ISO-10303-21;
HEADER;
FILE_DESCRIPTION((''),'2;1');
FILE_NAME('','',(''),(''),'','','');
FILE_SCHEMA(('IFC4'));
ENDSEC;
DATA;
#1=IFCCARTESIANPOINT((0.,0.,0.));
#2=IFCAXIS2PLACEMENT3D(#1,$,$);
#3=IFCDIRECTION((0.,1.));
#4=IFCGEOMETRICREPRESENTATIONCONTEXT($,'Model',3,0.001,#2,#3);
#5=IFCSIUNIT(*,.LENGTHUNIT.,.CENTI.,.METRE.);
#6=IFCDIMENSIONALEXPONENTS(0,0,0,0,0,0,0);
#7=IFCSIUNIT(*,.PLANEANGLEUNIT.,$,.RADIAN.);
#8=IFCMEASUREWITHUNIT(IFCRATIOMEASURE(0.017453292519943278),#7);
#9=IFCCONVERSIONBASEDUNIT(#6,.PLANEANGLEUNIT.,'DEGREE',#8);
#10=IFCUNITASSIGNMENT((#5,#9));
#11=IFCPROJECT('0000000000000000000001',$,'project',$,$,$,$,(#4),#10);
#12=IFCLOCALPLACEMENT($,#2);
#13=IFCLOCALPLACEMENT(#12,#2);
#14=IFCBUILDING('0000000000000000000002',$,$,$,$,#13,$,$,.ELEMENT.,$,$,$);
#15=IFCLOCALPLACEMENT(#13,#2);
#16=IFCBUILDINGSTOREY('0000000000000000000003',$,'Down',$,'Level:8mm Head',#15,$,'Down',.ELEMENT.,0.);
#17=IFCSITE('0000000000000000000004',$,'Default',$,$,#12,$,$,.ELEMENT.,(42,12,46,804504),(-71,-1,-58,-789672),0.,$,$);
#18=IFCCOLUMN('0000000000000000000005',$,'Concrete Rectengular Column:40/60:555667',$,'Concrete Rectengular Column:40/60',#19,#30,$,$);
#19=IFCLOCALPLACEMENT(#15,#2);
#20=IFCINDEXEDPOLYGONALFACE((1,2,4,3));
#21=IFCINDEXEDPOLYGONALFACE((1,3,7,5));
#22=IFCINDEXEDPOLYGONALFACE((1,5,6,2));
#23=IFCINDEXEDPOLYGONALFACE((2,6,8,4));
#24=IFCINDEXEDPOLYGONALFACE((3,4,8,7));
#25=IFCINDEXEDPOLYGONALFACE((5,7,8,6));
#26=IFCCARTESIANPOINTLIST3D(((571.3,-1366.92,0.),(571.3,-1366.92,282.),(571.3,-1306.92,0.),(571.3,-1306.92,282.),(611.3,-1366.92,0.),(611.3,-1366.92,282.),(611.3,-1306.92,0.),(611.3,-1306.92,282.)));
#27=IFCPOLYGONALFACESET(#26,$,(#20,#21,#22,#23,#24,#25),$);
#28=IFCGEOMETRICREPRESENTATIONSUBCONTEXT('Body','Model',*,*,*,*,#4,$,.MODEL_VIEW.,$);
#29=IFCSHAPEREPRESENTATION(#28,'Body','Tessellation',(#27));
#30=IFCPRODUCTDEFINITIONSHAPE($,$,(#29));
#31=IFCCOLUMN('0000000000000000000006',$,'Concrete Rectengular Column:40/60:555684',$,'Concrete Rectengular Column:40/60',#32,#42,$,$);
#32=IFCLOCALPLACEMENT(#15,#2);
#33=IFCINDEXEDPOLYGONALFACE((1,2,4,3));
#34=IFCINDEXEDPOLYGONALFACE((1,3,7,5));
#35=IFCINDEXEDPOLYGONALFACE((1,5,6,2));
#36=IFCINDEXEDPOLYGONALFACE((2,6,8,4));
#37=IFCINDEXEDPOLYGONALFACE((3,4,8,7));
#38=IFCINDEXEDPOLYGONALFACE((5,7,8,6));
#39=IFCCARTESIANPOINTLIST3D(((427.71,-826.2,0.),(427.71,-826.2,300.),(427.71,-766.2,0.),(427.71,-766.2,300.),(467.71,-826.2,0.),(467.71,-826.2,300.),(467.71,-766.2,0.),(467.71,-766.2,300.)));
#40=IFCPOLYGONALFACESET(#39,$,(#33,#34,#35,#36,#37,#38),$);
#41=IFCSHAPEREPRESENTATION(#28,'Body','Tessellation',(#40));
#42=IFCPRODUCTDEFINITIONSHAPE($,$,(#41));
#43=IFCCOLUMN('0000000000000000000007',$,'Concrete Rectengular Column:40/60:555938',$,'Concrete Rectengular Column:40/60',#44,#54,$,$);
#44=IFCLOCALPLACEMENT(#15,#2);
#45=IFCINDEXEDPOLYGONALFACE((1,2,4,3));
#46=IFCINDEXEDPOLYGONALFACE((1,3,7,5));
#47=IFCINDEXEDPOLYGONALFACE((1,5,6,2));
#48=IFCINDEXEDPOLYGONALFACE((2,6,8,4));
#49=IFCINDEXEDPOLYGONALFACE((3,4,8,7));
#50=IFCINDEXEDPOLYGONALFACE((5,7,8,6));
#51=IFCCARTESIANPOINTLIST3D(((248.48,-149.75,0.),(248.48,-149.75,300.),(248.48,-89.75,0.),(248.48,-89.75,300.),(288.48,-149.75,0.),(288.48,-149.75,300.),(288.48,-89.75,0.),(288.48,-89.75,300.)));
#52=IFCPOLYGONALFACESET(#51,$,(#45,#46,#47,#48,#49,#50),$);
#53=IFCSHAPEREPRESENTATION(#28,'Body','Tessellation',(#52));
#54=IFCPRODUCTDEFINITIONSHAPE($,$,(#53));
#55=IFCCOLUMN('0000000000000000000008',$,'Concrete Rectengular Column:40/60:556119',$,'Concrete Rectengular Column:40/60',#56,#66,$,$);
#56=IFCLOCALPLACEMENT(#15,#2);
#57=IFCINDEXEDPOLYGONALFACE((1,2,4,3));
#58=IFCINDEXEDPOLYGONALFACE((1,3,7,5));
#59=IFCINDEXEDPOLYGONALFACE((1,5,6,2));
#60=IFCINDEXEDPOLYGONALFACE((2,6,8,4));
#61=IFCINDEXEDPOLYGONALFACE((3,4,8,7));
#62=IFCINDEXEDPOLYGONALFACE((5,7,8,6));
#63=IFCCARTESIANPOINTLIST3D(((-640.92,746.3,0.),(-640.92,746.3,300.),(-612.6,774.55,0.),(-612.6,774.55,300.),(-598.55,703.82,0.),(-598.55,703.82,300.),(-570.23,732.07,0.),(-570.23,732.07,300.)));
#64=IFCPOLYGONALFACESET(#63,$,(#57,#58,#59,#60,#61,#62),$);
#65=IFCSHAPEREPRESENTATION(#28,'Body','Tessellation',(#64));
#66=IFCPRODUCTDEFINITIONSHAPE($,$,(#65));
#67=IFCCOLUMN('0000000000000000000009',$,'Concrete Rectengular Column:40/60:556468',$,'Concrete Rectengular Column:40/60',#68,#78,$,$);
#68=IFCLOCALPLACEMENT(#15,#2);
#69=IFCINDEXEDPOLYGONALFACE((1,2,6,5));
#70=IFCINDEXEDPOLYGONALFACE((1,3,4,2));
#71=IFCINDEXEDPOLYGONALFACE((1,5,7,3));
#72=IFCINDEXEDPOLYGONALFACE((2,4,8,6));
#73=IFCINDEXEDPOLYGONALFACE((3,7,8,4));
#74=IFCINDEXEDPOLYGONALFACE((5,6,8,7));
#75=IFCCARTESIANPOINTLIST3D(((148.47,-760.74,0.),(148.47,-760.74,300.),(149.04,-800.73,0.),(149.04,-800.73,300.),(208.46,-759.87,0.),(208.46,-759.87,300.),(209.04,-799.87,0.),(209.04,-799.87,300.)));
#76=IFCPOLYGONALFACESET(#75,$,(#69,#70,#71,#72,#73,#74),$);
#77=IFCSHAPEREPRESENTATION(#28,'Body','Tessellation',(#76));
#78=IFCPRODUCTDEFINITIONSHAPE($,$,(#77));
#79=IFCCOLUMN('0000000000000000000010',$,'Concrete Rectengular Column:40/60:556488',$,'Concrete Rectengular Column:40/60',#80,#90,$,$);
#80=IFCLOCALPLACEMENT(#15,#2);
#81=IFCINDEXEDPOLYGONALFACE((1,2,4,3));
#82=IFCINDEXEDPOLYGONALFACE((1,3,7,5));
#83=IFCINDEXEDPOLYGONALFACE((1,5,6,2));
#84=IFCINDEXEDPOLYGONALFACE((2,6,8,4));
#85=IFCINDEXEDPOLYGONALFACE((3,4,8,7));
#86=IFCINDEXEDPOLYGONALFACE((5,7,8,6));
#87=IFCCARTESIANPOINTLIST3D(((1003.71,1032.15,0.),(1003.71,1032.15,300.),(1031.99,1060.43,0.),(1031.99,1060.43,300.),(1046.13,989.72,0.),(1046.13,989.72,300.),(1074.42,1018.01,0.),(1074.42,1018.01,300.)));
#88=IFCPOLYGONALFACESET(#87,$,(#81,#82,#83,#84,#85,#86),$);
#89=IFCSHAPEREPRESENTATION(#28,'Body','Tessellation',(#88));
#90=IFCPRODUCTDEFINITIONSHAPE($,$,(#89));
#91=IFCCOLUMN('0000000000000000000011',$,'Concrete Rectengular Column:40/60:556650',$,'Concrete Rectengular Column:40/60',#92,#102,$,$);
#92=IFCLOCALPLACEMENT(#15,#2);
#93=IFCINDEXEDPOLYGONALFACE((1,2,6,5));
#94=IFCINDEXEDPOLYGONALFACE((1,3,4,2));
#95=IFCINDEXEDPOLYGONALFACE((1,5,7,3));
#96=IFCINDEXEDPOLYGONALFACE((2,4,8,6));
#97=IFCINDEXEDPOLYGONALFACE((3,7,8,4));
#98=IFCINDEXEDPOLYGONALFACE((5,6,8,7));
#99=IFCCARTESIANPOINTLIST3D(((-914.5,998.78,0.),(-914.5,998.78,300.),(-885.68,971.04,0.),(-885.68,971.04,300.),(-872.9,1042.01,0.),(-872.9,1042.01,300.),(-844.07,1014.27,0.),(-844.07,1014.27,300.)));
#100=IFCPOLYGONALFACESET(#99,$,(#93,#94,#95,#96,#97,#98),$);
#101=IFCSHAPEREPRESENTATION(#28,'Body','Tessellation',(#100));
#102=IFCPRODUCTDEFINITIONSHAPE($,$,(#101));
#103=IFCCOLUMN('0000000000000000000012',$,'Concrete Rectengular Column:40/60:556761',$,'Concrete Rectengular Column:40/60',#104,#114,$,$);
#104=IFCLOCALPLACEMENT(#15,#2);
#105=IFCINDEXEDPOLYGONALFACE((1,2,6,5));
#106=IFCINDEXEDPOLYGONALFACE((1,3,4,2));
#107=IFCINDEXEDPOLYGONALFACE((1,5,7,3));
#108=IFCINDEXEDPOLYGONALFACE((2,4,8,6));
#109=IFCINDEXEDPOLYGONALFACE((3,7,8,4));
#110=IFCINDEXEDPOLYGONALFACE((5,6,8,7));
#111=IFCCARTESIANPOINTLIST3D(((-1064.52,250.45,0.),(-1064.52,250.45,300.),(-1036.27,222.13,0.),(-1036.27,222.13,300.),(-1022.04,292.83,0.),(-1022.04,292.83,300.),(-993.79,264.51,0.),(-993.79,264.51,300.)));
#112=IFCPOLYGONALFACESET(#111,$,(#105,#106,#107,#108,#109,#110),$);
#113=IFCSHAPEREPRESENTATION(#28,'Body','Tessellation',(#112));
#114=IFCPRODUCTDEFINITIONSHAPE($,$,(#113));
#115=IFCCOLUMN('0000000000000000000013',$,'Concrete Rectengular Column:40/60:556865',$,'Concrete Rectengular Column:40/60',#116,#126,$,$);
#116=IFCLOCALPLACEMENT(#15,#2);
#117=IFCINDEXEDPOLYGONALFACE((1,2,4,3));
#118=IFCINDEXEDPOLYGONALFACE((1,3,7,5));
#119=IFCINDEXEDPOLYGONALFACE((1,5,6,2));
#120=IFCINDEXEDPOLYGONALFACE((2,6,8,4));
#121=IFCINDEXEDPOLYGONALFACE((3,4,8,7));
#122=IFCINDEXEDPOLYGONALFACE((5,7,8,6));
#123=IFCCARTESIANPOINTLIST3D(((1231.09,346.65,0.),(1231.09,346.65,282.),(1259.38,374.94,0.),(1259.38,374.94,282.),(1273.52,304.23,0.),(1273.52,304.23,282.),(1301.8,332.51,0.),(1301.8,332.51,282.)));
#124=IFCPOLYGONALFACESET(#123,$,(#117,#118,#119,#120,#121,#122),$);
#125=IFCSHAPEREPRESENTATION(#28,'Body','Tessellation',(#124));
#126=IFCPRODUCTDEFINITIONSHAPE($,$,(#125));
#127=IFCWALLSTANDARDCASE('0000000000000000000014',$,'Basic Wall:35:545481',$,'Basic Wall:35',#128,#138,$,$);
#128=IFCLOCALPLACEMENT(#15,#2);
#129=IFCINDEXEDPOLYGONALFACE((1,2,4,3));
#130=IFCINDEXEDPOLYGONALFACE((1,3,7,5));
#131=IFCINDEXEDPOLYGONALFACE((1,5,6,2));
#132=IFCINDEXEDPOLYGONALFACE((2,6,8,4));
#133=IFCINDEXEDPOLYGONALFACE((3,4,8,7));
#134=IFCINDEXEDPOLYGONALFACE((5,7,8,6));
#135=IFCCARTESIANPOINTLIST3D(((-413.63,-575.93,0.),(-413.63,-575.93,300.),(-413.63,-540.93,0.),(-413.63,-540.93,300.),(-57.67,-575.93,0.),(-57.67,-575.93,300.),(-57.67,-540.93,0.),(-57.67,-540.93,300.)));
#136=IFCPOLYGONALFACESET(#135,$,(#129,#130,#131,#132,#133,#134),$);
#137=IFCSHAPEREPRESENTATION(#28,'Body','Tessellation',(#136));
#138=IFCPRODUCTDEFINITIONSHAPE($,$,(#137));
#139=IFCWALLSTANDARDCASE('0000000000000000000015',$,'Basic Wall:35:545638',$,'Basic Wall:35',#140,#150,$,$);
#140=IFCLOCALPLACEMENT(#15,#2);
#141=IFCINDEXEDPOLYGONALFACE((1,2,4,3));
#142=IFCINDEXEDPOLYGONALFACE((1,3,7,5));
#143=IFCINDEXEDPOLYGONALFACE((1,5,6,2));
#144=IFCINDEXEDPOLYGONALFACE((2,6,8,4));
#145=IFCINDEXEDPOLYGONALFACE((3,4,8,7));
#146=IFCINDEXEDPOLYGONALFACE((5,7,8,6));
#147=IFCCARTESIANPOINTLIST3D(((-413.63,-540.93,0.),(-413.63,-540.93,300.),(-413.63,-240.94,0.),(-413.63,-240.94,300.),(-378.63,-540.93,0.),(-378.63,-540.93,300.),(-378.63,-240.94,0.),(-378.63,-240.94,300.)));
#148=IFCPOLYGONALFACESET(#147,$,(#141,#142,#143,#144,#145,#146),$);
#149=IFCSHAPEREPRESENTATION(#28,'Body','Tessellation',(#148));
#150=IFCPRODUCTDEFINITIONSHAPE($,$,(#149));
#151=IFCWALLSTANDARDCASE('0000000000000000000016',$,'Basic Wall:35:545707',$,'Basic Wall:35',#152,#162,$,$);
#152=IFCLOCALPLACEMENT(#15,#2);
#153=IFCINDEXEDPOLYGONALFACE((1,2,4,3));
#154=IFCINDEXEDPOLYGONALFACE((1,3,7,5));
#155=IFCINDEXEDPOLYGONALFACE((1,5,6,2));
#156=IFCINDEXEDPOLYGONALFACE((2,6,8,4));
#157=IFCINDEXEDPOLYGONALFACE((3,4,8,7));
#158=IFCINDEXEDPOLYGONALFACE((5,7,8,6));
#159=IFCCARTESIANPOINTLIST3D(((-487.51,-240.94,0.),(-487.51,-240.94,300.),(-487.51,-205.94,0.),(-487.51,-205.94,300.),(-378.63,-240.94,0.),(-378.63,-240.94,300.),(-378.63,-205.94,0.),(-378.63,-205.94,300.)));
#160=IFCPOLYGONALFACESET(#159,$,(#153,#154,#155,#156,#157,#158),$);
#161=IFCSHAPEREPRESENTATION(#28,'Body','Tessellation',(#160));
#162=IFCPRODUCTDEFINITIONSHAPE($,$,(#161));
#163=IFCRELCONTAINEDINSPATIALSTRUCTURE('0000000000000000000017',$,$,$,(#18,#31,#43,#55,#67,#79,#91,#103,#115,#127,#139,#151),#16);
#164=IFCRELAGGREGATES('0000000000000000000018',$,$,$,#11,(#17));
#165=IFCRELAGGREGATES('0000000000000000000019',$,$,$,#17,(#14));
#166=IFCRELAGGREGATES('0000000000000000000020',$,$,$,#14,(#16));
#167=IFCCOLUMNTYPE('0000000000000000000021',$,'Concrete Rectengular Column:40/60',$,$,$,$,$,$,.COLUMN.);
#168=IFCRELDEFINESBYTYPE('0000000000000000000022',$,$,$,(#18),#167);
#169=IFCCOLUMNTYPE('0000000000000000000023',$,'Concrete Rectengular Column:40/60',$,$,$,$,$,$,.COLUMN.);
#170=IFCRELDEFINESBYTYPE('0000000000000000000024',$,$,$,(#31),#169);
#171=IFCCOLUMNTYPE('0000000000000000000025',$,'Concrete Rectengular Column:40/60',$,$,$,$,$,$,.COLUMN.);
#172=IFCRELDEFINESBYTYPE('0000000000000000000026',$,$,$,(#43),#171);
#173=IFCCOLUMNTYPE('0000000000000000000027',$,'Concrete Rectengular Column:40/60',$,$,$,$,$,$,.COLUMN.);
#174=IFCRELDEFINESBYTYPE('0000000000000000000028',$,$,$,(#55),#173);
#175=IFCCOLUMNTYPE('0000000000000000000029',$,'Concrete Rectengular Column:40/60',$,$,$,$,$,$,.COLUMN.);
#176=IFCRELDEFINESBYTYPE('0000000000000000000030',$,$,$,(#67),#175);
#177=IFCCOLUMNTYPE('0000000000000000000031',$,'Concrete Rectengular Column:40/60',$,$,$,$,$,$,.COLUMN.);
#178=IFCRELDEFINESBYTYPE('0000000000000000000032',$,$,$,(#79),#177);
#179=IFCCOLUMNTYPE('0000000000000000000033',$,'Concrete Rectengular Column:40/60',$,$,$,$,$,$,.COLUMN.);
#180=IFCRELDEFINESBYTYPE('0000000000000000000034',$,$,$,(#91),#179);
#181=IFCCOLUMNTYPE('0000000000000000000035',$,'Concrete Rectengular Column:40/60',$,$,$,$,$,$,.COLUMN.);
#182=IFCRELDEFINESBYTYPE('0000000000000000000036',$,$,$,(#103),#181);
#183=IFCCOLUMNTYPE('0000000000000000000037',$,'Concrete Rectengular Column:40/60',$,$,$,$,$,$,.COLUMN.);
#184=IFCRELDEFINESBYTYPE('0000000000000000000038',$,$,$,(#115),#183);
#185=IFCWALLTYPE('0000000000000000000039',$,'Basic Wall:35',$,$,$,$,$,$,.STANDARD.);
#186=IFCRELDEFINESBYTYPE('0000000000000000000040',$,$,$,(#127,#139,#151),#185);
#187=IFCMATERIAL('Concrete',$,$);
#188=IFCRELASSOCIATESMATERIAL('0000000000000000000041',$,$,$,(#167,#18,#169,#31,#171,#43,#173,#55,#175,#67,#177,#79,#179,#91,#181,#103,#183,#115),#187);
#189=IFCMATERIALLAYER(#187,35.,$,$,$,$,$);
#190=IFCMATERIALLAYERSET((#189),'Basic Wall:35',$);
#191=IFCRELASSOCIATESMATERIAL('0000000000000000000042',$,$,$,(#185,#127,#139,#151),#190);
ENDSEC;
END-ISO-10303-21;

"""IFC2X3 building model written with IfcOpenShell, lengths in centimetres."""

from ifc_helpers import new_model, entity, si_unit, converted_unit, direction, frame, frame_2d, origin, origin_2d_with_axis, place, context, subcontext, project, spatial, rectangle, extrude, source, transform, mapped, material, layer, layer_set, layer_usage, type_object, type_shapes, element, save


model = new_model("IFC2X3")

# Units and contexts
model_context = context("Model", 3, precision=0.001, world=origin(), true_north=direction((0.0, 1.0)))
body_context = subcontext(model_context, "Body", "Model", "MODEL_VIEW")
ifc_project = project(units=[si_unit("LENGTHUNIT", "METRE", prefix="CENTI"), converted_unit("PLANEANGLEUNIT", "DEGREE", entity("IfcRatioMeasure", 0.017453292519943278), si_unit("PLANEANGLEUNIT", "RADIAN"), dimensions=[0, 0, 0, 0, 0, 0, 0])], contexts=[model_context])

# Site, building, storey
site_placement = place(None, origin())
site = spatial("IfcSite", under=ifc_project, at=site_placement, Name="Default", CompositionType="ELEMENT", RefLatitude=(42, 12, 46, 804504), RefLongitude=(-71, -1, -58, -789672), RefElevation=0.0)
building_placement = place(site_placement, origin())
building = spatial("IfcBuilding", under=site, at=building_placement, CompositionType="ELEMENT")
storey_placement = place(building_placement, origin())
storey = spatial("IfcBuildingStorey", under=building, at=storey_placement, Name="Down", ObjectType="Level:8mm Head", LongName="Down", CompositionType="ELEMENT", Elevation=0.0)

# Columns
ifc_material = material(Name="Concrete")
column_type_1 = type_object("IfcColumnType", Name="Concrete Rectengular Column:40/60", PredefinedType="COLUMN", material=ifc_material)
shared_shape_1 = source(origin(), body_context, "Body", "SweptSolid", [
    extrude(rectangle(XDim=60.0, YDim=40.0, at=frame_2d((0.0, 0.0), x_axis=(1.0, 0.0))), frame((591.3, -1336.92, 0.0), z_axis=(0.0, 0.0, 1.0), x_axis=(0.0, -1.0, 0.0)), (0.0, 0.0, 1.0), 282.0),
])
type_shapes(column_type_1, [shared_shape_1])
column_1_placement = place(storey_placement, origin())
element("IfcColumn", 1, at=column_1_placement, inside=storey, type_object=column_type_1, material=ifc_material, Name="Concrete Rectengular Column:40/60:555667", ObjectType="Concrete Rectengular Column:40/60", context=body_context, shape_type="MappedRepresentation", body=[
    mapped(shared_shape_1, transform((0.0, 0.0, 0.0), scale=1.0)),
])
column_type_2 = type_object("IfcColumnType", Name="Concrete Rectengular Column:40/60", PredefinedType="COLUMN", material=ifc_material)
shared_shape_2 = source(origin(), body_context, "Body", "SweptSolid", [
    extrude(rectangle(XDim=60.0, YDim=40.0, at=origin_2d_with_axis()), frame((447.71, -796.2, 0.0), z_axis=(0.0, 0.0, 1.0), x_axis=(0.0, -1.0, 0.0)), (0.0, 0.0, 1.0), 300.0),
])
type_shapes(column_type_2, [shared_shape_2])
column_2_placement = place(storey_placement, origin())
element("IfcColumn", 2, at=column_2_placement, inside=storey, type_object=column_type_2, material=ifc_material, Name="Concrete Rectengular Column:40/60:555684", ObjectType="Concrete Rectengular Column:40/60", context=body_context, shape_type="MappedRepresentation", body=[
    mapped(shared_shape_2, transform((0.0, 0.0, 0.0), scale=1.0)),
])
column_type_3 = type_object("IfcColumnType", Name="Concrete Rectengular Column:40/60", PredefinedType="COLUMN", material=ifc_material)
shared_shape_3 = source(origin(), body_context, "Body", "SweptSolid", [
    extrude(rectangle(XDim=60.0, YDim=40.0, at=frame_2d((0.0, 0.0), x_axis=(1.0, 0.0))), frame((268.48, -119.75, 0.0), z_axis=(0.0, 0.0, 1.0), x_axis=(0.0, -1.0, 0.0)), (0.0, 0.0, 1.0), 300.0),
])
type_shapes(column_type_3, [shared_shape_3])
column_3_placement = place(storey_placement, origin())
element("IfcColumn", 3, at=column_3_placement, inside=storey, type_object=column_type_3, material=ifc_material, Name="Concrete Rectengular Column:40/60:555938", ObjectType="Concrete Rectengular Column:40/60", context=body_context, shape_type="MappedRepresentation", body=[
    mapped(shared_shape_3, transform((0.0, 0.0, 0.0), scale=1.0)),
])
column_type_4 = type_object("IfcColumnType", Name="Concrete Rectengular Column:40/60", PredefinedType="COLUMN", material=ifc_material)
shared_shape_4 = source(origin(), body_context, "Body", "SweptSolid", [
    extrude(rectangle(XDim=60.0, YDim=40.0, at=frame_2d((0.0, 0.0), x_axis=(1.0, 0.0))), frame((-605.57, 739.18, 0.0), z_axis=(0.0, 0.0, 1.0), x_axis=(-0.706205, 0.708007, 0.0)), (0.0, 0.0, 1.0), 300.0),
])
type_shapes(column_type_4, [shared_shape_4])
column_4_placement = place(storey_placement, origin())
element("IfcColumn", 4, at=column_4_placement, inside=storey, type_object=column_type_4, material=ifc_material, Name="Concrete Rectengular Column:40/60:556119", ObjectType="Concrete Rectengular Column:40/60", context=body_context, shape_type="MappedRepresentation", body=[
    mapped(shared_shape_4, transform((0.0, 0.0, 0.0), scale=1.0)),
])
column_type_5 = type_object("IfcColumnType", Name="Concrete Rectengular Column:40/60", PredefinedType="COLUMN", material=ifc_material)
shared_shape_5 = source(origin(), body_context, "Body", "SweptSolid", [
    extrude(rectangle(XDim=60.0, YDim=40.0, at=origin_2d_with_axis()), frame((178.75, -780.3, 0.0), z_axis=(0.0, 0.0, 1.0), x_axis=(-0.999896, -0.014431, 0.0)), (0.0, 0.0, 1.0), 300.0),
])
type_shapes(column_type_5, [shared_shape_5])
column_5_placement = place(storey_placement, origin())
element("IfcColumn", 5, at=column_5_placement, inside=storey, type_object=column_type_5, material=ifc_material, Name="Concrete Rectengular Column:40/60:556468", ObjectType="Concrete Rectengular Column:40/60", context=body_context, shape_type="MappedRepresentation", body=[
    mapped(shared_shape_5, transform((0.0, 0.0, 0.0), scale=1.0)),
])
column_type_6 = type_object("IfcColumnType", Name="Concrete Rectengular Column:40/60", PredefinedType="COLUMN", material=ifc_material)
shared_shape_6 = source(origin(), body_context, "Body", "SweptSolid", [
    extrude(rectangle(XDim=60.0, YDim=40.0, at=frame_2d((0.0, 0.0), x_axis=(1.0, 0.0))), frame((1039.06, 1025.08, 0.0), z_axis=(0.0, 0.0, 1.0), x_axis=(-0.707107, 0.707107, 0.0)), (0.0, 0.0, 1.0), 300.0),
])
type_shapes(column_type_6, [shared_shape_6])
column_6_placement = place(storey_placement, origin())
element("IfcColumn", 6, at=column_6_placement, inside=storey, type_object=column_type_6, material=ifc_material, Name="Concrete Rectengular Column:40/60:556488", ObjectType="Concrete Rectengular Column:40/60", context=body_context, shape_type="MappedRepresentation", body=[
    mapped(shared_shape_6, transform((0.0, 0.0, 0.0), scale=1.0)),
])
column_type_7 = type_object("IfcColumnType", Name="Concrete Rectengular Column:40/60", PredefinedType="COLUMN", material=ifc_material)
shared_shape_7 = source(origin(), body_context, "Body", "SweptSolid", [
    extrude(rectangle(XDim=60.0, YDim=40.0, at=frame_2d((0.0, 0.0), x_axis=(1.0, 0.0))), frame((-879.29, 1006.52, 0.0), z_axis=(0.0, 0.0, 1.0), x_axis=(0.693433, 0.720521, 0.0)), (0.0, 0.0, 1.0), 300.0),
])
type_shapes(column_type_7, [shared_shape_7])
column_7_placement = place(storey_placement, origin())
element("IfcColumn", 7, at=column_7_placement, inside=storey, type_object=column_type_7, material=ifc_material, Name="Concrete Rectengular Column:40/60:556650", ObjectType="Concrete Rectengular Column:40/60", context=body_context, shape_type="MappedRepresentation", body=[
    mapped(shared_shape_7, transform((0.0, 0.0, 0.0), scale=1.0)),
])
column_type_8 = type_object("IfcColumnType", Name="Concrete Rectengular Column:40/60", PredefinedType="COLUMN", material=ifc_material)
shared_shape_8 = source(origin(), body_context, "Body", "SweptSolid", [
    extrude(rectangle(XDim=60.0, YDim=40.0, at=frame_2d((0.0, 0.0), x_axis=(1.0, 0.0))), frame((-1029.16, 257.48, 0.0), z_axis=(0.0, 0.0, 1.0), x_axis=(0.708007, 0.706205, 0.0)), (0.0, 0.0, 1.0), 300.0),
])
type_shapes(column_type_8, [shared_shape_8])
column_8_placement = place(storey_placement, origin())
element("IfcColumn", 8, at=column_8_placement, inside=storey, type_object=column_type_8, material=ifc_material, Name="Concrete Rectengular Column:40/60:556761", ObjectType="Concrete Rectengular Column:40/60", context=body_context, shape_type="MappedRepresentation", body=[
    mapped(shared_shape_8, transform((0.0, 0.0, 0.0), scale=1.0)),
])
column_type_9 = type_object("IfcColumnType", Name="Concrete Rectengular Column:40/60", PredefinedType="COLUMN", material=ifc_material)
shared_shape_9 = source(origin(), body_context, "Body", "SweptSolid", [
    extrude(rectangle(XDim=60.0, YDim=40.0, at=frame_2d((0.0, 0.0), x_axis=(1.0, 0.0))), frame((1266.45, 339.58, 0.0), z_axis=(0.0, 0.0, 1.0), x_axis=(-0.707107, 0.707107, 0.0)), (0.0, 0.0, 1.0), 282.0),
])
type_shapes(column_type_9, [shared_shape_9])
column_9_placement = place(storey_placement, origin())
element("IfcColumn", 9, at=column_9_placement, inside=storey, type_object=column_type_9, material=ifc_material, Name="Concrete Rectengular Column:40/60:556865", ObjectType="Concrete Rectengular Column:40/60", context=body_context, shape_type="MappedRepresentation", body=[
    mapped(shared_shape_9, transform((0.0, 0.0, 0.0), scale=1.0)),
])

# Walls
ifc_layer_1 = layer(ifc_material, 35.0)
ifc_layer_set_1 = layer_set([ifc_layer_1], Name="Basic Wall:35")
ifc_layer_usage_1 = layer_usage(ifc_layer_set_1, "AXIS2", "NEGATIVE", 17.5)
wall_type_1 = type_object("IfcWallType", Name="Basic Wall:35", PredefinedType="STANDARD", material=ifc_layer_set_1)
wall_1_placement = place(storey_placement, frame((-57.67, -558.43, 0.0), z_axis=(0.0, 0.0, 1.0), x_axis=(-1.0, 0.0, 0.0)))
element("IfcWallStandardCase", 10, at=wall_1_placement, inside=storey, type_object=wall_type_1, material=ifc_layer_usage_1, Name="Basic Wall:35:545481", ObjectType="Basic Wall:35", context=body_context, shape_type="SweptSolid", body=[
    extrude(rectangle(XDim=355.96, YDim=35.0, at=frame_2d((177.98, 0.0), x_axis=(-1.0, 0.0))), origin(), (0.0, 0.0, 1.0), 300.0),
])
ifc_layer_usage_2 = layer_usage(ifc_layer_set_1, "AXIS2", "NEGATIVE", 17.5)
wall_2_placement = place(storey_placement, frame((-396.13, -540.93, 0.0), z_axis=(0.0, 0.0, 1.0), x_axis=(0.0, 1.0, 0.0)))
element("IfcWallStandardCase", 11, at=wall_2_placement, inside=storey, type_object=wall_type_1, material=ifc_layer_usage_2, Name="Basic Wall:35:545638", ObjectType="Basic Wall:35", context=body_context, shape_type="SweptSolid", body=[
    extrude(rectangle(XDim=299.99, YDim=35.0, at=frame_2d((150.0, 0.0), x_axis=(-1.0, 0.0))), origin(), (0.0, 0.0, 1.0), 300.0),
])
ifc_layer_usage_3 = layer_usage(ifc_layer_set_1, "AXIS2", "POSITIVE", -17.5)
wall_3_placement = place(storey_placement, frame((-378.63, -223.44, 0.0), z_axis=(0.0, 0.0, 1.0), x_axis=(-1.0, 0.0, 0.0)))
element("IfcWallStandardCase", 12, at=wall_3_placement, inside=storey, type_object=wall_type_1, material=ifc_layer_usage_3, Name="Basic Wall:35:545707", ObjectType="Basic Wall:35", context=body_context, shape_type="SweptSolid", body=[
    extrude(rectangle(XDim=108.89, YDim=35.0, at=frame_2d((54.44, 0.0), x_axis=(-1.0, 0.0))), origin(), (0.0, 0.0, 1.0), 300.0),
])

save(model, "model.ifc")
